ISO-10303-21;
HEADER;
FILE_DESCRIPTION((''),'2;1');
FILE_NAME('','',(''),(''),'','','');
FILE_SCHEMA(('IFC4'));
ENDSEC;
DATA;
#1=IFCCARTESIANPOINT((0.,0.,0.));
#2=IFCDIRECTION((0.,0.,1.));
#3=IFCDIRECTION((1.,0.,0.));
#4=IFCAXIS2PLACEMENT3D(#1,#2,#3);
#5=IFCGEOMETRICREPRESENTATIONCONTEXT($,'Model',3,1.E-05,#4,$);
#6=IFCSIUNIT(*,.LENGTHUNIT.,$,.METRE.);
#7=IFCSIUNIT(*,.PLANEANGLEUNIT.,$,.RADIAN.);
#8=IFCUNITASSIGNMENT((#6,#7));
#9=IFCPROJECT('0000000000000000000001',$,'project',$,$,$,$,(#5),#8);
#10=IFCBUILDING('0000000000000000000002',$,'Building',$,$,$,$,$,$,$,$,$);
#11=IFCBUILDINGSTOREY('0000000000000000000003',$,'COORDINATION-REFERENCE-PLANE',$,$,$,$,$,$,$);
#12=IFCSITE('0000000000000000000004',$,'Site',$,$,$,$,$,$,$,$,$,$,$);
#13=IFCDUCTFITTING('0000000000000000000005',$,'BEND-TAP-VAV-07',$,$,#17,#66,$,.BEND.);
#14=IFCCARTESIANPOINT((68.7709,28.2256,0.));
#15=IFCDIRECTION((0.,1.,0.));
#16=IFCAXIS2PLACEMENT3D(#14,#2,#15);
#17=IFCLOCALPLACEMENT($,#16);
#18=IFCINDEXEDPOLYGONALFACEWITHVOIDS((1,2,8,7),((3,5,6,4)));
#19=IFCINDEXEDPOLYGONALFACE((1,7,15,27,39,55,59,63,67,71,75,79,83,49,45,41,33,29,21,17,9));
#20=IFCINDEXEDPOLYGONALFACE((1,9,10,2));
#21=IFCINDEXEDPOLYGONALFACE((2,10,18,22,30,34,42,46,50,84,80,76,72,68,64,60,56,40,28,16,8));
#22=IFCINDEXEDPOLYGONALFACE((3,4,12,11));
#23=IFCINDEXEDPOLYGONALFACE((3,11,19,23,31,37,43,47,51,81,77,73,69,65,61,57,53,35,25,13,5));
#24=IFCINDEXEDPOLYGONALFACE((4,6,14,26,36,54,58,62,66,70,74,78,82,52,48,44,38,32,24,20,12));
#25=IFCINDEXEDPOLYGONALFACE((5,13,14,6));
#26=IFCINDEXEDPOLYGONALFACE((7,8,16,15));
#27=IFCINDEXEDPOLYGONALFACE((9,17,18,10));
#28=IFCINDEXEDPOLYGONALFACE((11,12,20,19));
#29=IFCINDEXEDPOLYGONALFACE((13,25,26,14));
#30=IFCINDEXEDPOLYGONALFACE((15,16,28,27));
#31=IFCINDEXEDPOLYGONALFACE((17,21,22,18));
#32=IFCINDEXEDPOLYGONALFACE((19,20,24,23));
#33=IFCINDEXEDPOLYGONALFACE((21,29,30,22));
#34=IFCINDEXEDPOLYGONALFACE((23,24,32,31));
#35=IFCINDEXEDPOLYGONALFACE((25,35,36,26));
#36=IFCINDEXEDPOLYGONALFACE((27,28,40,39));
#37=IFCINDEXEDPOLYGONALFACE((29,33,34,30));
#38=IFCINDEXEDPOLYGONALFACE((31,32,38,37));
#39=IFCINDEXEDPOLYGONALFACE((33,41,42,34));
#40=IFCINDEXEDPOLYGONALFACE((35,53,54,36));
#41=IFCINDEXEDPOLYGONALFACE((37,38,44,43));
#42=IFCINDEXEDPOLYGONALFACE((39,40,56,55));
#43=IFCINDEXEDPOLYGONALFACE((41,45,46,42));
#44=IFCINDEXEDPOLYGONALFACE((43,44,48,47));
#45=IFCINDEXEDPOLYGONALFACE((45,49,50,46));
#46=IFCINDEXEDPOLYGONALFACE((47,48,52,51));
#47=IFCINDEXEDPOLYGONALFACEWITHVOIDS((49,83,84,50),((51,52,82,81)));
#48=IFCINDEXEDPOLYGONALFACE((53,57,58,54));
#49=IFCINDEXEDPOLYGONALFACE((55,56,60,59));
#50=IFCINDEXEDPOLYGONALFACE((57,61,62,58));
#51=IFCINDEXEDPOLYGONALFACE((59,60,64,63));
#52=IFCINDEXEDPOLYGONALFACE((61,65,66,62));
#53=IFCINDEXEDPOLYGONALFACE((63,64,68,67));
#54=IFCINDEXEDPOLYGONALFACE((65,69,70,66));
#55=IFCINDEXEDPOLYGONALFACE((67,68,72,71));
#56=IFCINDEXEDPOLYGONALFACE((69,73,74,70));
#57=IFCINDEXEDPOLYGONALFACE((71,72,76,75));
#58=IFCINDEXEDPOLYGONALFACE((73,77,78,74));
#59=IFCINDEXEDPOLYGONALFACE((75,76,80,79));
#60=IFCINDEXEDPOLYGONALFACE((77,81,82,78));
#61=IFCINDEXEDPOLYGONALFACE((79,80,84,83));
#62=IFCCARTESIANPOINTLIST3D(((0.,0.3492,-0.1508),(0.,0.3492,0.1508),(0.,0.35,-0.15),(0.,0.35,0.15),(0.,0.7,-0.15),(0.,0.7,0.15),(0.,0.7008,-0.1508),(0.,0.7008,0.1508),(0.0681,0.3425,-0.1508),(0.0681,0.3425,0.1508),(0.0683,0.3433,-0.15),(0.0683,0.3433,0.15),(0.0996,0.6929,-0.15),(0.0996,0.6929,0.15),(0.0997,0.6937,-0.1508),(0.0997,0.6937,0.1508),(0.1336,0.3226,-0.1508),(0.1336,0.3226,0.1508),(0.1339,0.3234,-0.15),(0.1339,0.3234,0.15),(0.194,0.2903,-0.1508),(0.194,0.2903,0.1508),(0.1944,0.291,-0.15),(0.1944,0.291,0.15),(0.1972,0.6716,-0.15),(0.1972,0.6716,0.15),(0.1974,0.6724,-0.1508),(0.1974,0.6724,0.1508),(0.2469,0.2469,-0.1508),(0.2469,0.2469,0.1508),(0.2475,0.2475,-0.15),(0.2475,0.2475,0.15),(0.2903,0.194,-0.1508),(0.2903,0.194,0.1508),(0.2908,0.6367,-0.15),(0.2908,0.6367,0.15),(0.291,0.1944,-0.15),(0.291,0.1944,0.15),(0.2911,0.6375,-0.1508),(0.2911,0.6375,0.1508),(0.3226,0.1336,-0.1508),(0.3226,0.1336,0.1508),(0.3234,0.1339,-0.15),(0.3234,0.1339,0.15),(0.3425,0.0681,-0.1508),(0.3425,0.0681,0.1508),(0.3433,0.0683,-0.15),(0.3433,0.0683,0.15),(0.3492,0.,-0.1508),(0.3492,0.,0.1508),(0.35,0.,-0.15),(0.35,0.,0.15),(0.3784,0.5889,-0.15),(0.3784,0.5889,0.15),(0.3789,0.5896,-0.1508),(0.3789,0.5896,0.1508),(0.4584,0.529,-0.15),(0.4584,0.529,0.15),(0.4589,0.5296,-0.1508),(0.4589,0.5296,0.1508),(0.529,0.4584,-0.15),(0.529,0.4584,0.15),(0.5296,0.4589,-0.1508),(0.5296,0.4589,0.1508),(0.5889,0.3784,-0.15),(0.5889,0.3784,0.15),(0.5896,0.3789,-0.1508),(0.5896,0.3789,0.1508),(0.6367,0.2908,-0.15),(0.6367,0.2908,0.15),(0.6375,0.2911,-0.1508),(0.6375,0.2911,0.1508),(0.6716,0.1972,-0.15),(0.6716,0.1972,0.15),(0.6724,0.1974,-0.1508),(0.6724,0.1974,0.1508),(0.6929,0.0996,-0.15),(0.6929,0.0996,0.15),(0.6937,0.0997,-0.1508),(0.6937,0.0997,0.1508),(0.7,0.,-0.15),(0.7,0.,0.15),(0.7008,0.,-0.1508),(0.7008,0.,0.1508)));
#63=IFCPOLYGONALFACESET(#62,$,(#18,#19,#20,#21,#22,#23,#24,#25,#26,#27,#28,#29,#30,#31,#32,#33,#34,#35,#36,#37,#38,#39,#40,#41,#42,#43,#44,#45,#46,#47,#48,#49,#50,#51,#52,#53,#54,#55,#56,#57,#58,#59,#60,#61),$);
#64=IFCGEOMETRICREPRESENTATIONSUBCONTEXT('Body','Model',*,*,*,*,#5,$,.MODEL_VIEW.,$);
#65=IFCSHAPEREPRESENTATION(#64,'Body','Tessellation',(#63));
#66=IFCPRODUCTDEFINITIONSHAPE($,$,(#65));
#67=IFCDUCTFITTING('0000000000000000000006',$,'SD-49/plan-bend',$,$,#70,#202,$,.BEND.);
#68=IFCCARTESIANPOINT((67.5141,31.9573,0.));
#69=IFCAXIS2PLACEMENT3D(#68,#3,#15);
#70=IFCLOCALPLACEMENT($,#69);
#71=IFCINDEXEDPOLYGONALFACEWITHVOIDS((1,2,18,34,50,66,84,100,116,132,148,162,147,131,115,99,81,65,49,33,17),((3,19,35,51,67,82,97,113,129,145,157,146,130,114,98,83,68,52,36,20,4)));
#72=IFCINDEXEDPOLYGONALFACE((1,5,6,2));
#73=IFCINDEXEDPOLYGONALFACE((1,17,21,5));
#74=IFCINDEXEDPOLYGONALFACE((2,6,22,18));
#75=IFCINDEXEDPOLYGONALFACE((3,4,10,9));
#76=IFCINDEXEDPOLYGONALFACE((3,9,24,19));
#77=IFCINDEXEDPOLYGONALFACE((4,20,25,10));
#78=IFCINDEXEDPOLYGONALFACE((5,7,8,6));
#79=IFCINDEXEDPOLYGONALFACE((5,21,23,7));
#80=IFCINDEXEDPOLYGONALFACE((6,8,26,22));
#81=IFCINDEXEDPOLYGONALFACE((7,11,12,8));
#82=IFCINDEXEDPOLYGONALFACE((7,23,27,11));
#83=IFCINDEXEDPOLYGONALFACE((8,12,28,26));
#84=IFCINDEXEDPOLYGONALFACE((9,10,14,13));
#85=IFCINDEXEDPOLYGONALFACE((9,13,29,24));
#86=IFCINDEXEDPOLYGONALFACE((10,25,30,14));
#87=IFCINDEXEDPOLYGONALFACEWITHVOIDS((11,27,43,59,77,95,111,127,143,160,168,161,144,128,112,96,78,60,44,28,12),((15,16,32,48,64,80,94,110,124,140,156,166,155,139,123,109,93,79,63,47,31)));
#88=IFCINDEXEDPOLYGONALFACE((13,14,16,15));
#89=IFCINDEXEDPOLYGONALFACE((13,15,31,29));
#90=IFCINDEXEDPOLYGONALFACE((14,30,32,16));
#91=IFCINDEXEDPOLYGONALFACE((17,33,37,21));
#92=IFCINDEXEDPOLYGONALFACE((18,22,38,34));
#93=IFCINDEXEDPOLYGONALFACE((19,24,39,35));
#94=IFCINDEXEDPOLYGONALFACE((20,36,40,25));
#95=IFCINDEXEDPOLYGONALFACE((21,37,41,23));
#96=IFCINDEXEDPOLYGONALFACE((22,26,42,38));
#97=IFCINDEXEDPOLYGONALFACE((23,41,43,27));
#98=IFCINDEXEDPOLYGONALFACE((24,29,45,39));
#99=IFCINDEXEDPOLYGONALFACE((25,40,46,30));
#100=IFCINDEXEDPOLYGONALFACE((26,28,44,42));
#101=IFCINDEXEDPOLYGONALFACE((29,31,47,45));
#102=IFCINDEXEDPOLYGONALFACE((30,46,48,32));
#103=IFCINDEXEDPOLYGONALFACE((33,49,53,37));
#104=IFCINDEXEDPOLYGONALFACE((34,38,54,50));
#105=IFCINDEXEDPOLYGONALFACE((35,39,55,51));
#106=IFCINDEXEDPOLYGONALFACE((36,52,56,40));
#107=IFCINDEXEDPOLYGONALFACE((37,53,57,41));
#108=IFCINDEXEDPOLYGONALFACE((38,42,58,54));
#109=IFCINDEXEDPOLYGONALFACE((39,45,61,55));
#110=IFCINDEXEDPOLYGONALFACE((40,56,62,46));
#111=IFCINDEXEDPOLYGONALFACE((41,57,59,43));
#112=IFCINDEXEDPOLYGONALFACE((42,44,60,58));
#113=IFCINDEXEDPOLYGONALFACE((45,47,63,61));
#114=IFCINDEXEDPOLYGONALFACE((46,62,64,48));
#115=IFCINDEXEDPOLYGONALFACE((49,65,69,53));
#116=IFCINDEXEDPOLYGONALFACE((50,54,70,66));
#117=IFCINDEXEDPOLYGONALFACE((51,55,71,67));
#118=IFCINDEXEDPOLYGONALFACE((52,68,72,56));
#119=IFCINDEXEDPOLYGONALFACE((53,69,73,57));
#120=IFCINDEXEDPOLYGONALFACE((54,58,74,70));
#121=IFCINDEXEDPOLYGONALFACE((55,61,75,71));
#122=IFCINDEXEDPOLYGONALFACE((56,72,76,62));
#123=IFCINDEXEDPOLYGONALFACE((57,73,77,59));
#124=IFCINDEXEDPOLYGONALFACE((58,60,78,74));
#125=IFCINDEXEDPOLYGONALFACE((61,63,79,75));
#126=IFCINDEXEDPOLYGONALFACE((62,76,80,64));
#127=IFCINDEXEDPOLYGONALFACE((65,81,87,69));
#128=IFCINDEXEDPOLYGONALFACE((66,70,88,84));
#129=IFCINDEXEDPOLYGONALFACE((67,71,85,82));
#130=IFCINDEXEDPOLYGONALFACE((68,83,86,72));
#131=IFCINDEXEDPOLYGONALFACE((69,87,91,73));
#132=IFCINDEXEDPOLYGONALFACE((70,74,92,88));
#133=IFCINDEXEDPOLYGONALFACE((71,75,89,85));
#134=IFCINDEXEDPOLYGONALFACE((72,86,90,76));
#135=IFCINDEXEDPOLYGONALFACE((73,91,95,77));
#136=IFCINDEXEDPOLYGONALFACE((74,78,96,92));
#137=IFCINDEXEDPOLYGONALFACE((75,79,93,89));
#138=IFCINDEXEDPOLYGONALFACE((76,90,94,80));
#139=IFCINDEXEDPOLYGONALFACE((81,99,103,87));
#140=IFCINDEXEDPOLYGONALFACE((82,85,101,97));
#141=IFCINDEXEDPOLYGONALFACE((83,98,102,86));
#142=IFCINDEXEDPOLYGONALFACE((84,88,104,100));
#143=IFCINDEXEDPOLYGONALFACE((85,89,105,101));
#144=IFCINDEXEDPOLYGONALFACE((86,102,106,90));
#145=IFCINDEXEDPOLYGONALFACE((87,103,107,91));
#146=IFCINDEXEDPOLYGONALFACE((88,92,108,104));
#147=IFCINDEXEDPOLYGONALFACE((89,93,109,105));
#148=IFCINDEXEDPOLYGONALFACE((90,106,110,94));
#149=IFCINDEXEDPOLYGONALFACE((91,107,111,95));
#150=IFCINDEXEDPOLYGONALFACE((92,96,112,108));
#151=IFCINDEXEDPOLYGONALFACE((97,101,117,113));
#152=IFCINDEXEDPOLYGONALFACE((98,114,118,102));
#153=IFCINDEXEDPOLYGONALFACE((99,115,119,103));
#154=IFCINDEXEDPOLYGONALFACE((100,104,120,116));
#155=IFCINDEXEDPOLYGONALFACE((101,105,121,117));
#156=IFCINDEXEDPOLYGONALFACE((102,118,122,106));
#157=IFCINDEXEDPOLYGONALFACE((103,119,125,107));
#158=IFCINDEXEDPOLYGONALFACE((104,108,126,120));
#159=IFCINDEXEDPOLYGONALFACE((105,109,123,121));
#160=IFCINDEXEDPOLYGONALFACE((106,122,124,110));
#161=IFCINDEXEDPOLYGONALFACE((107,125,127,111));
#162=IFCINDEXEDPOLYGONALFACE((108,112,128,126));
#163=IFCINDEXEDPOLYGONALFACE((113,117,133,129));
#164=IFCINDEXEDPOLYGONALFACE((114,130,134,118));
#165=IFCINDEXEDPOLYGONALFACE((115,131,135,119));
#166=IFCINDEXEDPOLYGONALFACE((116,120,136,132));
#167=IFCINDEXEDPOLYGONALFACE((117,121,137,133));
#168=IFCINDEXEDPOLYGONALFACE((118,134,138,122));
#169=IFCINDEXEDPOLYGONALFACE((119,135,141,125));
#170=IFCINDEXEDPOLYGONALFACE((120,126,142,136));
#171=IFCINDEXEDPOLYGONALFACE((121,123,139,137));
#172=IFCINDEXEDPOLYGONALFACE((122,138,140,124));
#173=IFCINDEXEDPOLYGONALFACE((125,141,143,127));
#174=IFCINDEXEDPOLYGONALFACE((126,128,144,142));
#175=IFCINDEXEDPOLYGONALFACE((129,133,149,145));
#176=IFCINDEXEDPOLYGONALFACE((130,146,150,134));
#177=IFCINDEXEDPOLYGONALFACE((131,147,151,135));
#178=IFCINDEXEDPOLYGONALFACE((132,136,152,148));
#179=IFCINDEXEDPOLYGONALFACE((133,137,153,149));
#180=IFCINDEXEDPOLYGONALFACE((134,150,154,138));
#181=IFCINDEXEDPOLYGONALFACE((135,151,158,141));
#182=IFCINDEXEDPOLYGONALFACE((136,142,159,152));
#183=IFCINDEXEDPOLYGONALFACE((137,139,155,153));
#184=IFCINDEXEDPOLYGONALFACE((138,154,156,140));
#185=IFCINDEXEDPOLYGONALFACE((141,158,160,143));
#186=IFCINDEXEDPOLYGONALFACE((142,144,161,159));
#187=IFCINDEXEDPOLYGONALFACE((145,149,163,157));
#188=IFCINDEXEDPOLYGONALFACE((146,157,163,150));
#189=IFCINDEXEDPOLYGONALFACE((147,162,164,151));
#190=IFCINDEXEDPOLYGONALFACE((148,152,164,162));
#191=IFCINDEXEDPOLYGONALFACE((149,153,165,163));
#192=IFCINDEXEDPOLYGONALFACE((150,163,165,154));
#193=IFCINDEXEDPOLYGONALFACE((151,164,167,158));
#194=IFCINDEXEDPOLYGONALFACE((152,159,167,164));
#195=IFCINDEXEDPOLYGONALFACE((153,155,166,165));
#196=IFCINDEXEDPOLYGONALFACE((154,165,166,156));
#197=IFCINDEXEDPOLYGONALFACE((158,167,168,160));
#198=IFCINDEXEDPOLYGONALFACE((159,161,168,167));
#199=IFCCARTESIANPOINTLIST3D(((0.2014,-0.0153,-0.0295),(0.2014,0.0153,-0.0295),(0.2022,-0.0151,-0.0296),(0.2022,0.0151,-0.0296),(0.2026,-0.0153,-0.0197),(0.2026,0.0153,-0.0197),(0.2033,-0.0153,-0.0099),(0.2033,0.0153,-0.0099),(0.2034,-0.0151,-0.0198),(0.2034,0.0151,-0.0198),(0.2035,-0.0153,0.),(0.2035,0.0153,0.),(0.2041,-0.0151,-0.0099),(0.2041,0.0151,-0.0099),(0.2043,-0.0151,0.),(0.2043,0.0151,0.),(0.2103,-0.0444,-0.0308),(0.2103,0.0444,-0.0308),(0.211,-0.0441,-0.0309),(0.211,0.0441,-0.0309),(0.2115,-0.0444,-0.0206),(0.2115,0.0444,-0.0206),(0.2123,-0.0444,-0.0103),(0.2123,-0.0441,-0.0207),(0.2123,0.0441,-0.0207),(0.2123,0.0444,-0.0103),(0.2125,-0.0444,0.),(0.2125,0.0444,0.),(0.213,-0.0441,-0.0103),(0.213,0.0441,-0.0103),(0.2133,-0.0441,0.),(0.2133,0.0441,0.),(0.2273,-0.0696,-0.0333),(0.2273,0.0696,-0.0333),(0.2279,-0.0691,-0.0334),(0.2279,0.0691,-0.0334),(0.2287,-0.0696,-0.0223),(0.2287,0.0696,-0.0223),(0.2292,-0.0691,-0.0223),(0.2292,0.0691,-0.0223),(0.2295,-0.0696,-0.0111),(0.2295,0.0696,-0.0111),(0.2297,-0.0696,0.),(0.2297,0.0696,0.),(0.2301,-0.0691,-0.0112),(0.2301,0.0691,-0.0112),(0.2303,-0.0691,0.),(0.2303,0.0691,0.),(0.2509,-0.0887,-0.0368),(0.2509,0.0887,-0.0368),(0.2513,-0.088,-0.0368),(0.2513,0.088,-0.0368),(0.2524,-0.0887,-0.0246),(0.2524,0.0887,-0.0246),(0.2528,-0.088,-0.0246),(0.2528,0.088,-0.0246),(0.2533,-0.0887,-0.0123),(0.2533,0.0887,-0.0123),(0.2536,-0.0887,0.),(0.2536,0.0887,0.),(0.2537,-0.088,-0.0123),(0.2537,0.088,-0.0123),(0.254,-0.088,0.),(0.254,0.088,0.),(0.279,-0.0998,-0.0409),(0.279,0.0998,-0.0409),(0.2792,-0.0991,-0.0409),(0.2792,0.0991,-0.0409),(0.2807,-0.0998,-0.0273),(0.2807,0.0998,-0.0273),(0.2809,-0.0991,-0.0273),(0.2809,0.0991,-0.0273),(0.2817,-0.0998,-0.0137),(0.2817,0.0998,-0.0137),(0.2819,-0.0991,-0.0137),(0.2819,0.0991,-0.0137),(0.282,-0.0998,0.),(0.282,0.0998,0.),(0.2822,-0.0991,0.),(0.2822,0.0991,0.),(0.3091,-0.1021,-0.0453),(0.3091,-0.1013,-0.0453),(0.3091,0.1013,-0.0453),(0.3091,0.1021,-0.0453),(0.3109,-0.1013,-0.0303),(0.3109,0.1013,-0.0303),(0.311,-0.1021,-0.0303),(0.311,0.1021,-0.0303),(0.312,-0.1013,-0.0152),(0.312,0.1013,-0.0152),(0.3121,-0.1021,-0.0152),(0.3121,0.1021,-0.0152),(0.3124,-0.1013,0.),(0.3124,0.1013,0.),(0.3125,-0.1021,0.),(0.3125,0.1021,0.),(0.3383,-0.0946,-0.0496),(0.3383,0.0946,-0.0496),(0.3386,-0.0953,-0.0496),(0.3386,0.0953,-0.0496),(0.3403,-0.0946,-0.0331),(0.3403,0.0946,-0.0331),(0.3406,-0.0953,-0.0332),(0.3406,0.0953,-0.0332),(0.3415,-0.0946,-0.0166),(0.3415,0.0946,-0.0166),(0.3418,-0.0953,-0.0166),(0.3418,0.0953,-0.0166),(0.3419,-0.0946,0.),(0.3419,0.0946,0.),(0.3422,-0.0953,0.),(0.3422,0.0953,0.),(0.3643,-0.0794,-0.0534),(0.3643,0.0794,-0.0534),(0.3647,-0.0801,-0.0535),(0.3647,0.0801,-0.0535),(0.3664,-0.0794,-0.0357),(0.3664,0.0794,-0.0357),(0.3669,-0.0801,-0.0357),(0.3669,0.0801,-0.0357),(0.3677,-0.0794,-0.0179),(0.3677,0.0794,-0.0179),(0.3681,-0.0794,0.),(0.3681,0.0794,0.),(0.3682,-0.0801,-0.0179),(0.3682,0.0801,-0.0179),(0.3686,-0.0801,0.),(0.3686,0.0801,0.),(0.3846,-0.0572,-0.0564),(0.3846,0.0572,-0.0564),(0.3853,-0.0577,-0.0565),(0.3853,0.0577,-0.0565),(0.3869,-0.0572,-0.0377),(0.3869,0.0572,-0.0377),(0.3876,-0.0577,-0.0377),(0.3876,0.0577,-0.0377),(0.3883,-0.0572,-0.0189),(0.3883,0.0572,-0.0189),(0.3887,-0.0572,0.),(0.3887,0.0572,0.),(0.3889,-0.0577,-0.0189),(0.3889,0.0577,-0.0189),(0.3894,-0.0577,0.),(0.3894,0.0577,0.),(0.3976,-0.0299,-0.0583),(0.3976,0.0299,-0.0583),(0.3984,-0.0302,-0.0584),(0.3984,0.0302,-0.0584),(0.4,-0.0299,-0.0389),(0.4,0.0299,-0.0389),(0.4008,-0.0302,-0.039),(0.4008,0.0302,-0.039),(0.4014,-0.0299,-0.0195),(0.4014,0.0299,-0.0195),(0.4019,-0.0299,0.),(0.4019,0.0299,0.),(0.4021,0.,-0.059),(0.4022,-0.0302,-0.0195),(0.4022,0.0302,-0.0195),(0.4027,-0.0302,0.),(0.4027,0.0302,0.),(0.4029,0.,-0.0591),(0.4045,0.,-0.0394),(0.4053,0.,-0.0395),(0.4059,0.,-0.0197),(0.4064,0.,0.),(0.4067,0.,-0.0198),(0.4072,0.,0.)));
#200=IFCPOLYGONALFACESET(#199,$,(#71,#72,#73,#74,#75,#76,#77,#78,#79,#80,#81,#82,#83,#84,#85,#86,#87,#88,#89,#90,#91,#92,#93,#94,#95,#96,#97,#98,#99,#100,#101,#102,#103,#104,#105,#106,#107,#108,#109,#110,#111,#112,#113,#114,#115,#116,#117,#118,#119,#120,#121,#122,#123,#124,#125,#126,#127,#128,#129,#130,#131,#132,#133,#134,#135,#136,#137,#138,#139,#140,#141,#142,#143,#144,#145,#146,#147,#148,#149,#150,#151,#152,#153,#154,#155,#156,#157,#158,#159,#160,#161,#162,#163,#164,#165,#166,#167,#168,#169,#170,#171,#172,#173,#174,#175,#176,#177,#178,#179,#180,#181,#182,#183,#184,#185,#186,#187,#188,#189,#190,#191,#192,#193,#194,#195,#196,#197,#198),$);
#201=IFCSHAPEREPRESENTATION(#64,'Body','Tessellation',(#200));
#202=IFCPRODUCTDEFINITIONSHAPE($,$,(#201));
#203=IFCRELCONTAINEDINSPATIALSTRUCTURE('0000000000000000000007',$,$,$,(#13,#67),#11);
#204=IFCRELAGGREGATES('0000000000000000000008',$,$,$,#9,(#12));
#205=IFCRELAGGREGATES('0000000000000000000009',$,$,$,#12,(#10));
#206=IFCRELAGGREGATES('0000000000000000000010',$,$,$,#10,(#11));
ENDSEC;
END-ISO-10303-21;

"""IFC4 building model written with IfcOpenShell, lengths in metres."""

from ifc_helpers import new_model, entity, si_unit, frame, origin_with_axes, place, context, subcontext, project, spatial, element, save


model = new_model("IFC4")

# Units and contexts
model_context = context("Model", 3, precision=1e-05, world=origin_with_axes())
body_context_1 = subcontext(model_context, "Body", "Model", "MODEL_VIEW")
ifc_project = project(units=[si_unit("LENGTHUNIT", "METRE"), si_unit("PLANEANGLEUNIT", "RADIAN")], contexts=[model_context])

# Site, building, storey
site = spatial("IfcSite", under=ifc_project, Name="Site")
building = spatial("IfcBuilding", under=site, Name="Building")
storey = spatial("IfcBuildingStorey", under=building, Name="COORDINATION-REFERENCE-PLANE")

# Duct fitting
duct_fitting_1_placement = place(None, frame((68.7709, 28.2256, 0.0), z_axis=(0.0, 0.0, 1.0), x_axis=(0.0, 1.0, 0.0)))
cartesian_point = entity("IfcCartesianPoint", [0.0, 0.0, 0.0])
element("IfcDuctFitting", 1, at=duct_fitting_1_placement, inside=storey, Name="BEND-TAP-VAV-07", PredefinedType="BEND", context=body_context_1, shape_type="SweptSolid", body=[
    entity("IfcRevolvedAreaSolid", entity("IfcRectangleHollowProfileDef", "AREA", None, entity("IfcAxis2Placement2D", entity("IfcCartesianPoint", [0.525, 0.0])), 0.3516, 0.3016, 0.0008), entity("IfcAxis2Placement3D", cartesian_point, entity("IfcDirection", [0.0, -1.0, 0.0]), entity("IfcDirection", [1.0, 0.0, 0.0])), entity("IfcAxis1Placement", cartesian_point, entity("IfcDirection", [0.0, 1.0, 0.0])), 1.570796),
])

# Duct fitting
duct_fitting_2_placement = place(None, frame((67.5141, 31.9573, 0.0), z_axis=(1.0, 0.0, 0.0), x_axis=(0.0, 1.0, 0.0)))
element("IfcDuctFitting", 2, at=duct_fitting_2_placement, inside=storey, Name="SD-49/plan-bend", PredefinedType="BEND", context=body_context_1, shape_type="SweptSolid", body=[
    entity("IfcRevolvedAreaSolid", entity("IfcCircleHollowProfileDef", "AREA", None, entity("IfcAxis2Placement2D", entity("IfcCartesianPoint", [0.3048, 0.0])), 0.1024, 0.0008), entity("IfcAxis2Placement3D", entity("IfcCartesianPoint", [0.0, 0.0, 0.0]), entity("IfcDirection", [0.0, 0.0, 1.0]), entity("IfcDirection", [1.0, 0.0, 0.0])), entity("IfcAxis1Placement", entity("IfcCartesianPoint", [0.0, 0.0, 0.0]), entity("IfcDirection", [0.0, 1.0, 0.0])), 0.145576),
])

save(model, "model.ifc")
